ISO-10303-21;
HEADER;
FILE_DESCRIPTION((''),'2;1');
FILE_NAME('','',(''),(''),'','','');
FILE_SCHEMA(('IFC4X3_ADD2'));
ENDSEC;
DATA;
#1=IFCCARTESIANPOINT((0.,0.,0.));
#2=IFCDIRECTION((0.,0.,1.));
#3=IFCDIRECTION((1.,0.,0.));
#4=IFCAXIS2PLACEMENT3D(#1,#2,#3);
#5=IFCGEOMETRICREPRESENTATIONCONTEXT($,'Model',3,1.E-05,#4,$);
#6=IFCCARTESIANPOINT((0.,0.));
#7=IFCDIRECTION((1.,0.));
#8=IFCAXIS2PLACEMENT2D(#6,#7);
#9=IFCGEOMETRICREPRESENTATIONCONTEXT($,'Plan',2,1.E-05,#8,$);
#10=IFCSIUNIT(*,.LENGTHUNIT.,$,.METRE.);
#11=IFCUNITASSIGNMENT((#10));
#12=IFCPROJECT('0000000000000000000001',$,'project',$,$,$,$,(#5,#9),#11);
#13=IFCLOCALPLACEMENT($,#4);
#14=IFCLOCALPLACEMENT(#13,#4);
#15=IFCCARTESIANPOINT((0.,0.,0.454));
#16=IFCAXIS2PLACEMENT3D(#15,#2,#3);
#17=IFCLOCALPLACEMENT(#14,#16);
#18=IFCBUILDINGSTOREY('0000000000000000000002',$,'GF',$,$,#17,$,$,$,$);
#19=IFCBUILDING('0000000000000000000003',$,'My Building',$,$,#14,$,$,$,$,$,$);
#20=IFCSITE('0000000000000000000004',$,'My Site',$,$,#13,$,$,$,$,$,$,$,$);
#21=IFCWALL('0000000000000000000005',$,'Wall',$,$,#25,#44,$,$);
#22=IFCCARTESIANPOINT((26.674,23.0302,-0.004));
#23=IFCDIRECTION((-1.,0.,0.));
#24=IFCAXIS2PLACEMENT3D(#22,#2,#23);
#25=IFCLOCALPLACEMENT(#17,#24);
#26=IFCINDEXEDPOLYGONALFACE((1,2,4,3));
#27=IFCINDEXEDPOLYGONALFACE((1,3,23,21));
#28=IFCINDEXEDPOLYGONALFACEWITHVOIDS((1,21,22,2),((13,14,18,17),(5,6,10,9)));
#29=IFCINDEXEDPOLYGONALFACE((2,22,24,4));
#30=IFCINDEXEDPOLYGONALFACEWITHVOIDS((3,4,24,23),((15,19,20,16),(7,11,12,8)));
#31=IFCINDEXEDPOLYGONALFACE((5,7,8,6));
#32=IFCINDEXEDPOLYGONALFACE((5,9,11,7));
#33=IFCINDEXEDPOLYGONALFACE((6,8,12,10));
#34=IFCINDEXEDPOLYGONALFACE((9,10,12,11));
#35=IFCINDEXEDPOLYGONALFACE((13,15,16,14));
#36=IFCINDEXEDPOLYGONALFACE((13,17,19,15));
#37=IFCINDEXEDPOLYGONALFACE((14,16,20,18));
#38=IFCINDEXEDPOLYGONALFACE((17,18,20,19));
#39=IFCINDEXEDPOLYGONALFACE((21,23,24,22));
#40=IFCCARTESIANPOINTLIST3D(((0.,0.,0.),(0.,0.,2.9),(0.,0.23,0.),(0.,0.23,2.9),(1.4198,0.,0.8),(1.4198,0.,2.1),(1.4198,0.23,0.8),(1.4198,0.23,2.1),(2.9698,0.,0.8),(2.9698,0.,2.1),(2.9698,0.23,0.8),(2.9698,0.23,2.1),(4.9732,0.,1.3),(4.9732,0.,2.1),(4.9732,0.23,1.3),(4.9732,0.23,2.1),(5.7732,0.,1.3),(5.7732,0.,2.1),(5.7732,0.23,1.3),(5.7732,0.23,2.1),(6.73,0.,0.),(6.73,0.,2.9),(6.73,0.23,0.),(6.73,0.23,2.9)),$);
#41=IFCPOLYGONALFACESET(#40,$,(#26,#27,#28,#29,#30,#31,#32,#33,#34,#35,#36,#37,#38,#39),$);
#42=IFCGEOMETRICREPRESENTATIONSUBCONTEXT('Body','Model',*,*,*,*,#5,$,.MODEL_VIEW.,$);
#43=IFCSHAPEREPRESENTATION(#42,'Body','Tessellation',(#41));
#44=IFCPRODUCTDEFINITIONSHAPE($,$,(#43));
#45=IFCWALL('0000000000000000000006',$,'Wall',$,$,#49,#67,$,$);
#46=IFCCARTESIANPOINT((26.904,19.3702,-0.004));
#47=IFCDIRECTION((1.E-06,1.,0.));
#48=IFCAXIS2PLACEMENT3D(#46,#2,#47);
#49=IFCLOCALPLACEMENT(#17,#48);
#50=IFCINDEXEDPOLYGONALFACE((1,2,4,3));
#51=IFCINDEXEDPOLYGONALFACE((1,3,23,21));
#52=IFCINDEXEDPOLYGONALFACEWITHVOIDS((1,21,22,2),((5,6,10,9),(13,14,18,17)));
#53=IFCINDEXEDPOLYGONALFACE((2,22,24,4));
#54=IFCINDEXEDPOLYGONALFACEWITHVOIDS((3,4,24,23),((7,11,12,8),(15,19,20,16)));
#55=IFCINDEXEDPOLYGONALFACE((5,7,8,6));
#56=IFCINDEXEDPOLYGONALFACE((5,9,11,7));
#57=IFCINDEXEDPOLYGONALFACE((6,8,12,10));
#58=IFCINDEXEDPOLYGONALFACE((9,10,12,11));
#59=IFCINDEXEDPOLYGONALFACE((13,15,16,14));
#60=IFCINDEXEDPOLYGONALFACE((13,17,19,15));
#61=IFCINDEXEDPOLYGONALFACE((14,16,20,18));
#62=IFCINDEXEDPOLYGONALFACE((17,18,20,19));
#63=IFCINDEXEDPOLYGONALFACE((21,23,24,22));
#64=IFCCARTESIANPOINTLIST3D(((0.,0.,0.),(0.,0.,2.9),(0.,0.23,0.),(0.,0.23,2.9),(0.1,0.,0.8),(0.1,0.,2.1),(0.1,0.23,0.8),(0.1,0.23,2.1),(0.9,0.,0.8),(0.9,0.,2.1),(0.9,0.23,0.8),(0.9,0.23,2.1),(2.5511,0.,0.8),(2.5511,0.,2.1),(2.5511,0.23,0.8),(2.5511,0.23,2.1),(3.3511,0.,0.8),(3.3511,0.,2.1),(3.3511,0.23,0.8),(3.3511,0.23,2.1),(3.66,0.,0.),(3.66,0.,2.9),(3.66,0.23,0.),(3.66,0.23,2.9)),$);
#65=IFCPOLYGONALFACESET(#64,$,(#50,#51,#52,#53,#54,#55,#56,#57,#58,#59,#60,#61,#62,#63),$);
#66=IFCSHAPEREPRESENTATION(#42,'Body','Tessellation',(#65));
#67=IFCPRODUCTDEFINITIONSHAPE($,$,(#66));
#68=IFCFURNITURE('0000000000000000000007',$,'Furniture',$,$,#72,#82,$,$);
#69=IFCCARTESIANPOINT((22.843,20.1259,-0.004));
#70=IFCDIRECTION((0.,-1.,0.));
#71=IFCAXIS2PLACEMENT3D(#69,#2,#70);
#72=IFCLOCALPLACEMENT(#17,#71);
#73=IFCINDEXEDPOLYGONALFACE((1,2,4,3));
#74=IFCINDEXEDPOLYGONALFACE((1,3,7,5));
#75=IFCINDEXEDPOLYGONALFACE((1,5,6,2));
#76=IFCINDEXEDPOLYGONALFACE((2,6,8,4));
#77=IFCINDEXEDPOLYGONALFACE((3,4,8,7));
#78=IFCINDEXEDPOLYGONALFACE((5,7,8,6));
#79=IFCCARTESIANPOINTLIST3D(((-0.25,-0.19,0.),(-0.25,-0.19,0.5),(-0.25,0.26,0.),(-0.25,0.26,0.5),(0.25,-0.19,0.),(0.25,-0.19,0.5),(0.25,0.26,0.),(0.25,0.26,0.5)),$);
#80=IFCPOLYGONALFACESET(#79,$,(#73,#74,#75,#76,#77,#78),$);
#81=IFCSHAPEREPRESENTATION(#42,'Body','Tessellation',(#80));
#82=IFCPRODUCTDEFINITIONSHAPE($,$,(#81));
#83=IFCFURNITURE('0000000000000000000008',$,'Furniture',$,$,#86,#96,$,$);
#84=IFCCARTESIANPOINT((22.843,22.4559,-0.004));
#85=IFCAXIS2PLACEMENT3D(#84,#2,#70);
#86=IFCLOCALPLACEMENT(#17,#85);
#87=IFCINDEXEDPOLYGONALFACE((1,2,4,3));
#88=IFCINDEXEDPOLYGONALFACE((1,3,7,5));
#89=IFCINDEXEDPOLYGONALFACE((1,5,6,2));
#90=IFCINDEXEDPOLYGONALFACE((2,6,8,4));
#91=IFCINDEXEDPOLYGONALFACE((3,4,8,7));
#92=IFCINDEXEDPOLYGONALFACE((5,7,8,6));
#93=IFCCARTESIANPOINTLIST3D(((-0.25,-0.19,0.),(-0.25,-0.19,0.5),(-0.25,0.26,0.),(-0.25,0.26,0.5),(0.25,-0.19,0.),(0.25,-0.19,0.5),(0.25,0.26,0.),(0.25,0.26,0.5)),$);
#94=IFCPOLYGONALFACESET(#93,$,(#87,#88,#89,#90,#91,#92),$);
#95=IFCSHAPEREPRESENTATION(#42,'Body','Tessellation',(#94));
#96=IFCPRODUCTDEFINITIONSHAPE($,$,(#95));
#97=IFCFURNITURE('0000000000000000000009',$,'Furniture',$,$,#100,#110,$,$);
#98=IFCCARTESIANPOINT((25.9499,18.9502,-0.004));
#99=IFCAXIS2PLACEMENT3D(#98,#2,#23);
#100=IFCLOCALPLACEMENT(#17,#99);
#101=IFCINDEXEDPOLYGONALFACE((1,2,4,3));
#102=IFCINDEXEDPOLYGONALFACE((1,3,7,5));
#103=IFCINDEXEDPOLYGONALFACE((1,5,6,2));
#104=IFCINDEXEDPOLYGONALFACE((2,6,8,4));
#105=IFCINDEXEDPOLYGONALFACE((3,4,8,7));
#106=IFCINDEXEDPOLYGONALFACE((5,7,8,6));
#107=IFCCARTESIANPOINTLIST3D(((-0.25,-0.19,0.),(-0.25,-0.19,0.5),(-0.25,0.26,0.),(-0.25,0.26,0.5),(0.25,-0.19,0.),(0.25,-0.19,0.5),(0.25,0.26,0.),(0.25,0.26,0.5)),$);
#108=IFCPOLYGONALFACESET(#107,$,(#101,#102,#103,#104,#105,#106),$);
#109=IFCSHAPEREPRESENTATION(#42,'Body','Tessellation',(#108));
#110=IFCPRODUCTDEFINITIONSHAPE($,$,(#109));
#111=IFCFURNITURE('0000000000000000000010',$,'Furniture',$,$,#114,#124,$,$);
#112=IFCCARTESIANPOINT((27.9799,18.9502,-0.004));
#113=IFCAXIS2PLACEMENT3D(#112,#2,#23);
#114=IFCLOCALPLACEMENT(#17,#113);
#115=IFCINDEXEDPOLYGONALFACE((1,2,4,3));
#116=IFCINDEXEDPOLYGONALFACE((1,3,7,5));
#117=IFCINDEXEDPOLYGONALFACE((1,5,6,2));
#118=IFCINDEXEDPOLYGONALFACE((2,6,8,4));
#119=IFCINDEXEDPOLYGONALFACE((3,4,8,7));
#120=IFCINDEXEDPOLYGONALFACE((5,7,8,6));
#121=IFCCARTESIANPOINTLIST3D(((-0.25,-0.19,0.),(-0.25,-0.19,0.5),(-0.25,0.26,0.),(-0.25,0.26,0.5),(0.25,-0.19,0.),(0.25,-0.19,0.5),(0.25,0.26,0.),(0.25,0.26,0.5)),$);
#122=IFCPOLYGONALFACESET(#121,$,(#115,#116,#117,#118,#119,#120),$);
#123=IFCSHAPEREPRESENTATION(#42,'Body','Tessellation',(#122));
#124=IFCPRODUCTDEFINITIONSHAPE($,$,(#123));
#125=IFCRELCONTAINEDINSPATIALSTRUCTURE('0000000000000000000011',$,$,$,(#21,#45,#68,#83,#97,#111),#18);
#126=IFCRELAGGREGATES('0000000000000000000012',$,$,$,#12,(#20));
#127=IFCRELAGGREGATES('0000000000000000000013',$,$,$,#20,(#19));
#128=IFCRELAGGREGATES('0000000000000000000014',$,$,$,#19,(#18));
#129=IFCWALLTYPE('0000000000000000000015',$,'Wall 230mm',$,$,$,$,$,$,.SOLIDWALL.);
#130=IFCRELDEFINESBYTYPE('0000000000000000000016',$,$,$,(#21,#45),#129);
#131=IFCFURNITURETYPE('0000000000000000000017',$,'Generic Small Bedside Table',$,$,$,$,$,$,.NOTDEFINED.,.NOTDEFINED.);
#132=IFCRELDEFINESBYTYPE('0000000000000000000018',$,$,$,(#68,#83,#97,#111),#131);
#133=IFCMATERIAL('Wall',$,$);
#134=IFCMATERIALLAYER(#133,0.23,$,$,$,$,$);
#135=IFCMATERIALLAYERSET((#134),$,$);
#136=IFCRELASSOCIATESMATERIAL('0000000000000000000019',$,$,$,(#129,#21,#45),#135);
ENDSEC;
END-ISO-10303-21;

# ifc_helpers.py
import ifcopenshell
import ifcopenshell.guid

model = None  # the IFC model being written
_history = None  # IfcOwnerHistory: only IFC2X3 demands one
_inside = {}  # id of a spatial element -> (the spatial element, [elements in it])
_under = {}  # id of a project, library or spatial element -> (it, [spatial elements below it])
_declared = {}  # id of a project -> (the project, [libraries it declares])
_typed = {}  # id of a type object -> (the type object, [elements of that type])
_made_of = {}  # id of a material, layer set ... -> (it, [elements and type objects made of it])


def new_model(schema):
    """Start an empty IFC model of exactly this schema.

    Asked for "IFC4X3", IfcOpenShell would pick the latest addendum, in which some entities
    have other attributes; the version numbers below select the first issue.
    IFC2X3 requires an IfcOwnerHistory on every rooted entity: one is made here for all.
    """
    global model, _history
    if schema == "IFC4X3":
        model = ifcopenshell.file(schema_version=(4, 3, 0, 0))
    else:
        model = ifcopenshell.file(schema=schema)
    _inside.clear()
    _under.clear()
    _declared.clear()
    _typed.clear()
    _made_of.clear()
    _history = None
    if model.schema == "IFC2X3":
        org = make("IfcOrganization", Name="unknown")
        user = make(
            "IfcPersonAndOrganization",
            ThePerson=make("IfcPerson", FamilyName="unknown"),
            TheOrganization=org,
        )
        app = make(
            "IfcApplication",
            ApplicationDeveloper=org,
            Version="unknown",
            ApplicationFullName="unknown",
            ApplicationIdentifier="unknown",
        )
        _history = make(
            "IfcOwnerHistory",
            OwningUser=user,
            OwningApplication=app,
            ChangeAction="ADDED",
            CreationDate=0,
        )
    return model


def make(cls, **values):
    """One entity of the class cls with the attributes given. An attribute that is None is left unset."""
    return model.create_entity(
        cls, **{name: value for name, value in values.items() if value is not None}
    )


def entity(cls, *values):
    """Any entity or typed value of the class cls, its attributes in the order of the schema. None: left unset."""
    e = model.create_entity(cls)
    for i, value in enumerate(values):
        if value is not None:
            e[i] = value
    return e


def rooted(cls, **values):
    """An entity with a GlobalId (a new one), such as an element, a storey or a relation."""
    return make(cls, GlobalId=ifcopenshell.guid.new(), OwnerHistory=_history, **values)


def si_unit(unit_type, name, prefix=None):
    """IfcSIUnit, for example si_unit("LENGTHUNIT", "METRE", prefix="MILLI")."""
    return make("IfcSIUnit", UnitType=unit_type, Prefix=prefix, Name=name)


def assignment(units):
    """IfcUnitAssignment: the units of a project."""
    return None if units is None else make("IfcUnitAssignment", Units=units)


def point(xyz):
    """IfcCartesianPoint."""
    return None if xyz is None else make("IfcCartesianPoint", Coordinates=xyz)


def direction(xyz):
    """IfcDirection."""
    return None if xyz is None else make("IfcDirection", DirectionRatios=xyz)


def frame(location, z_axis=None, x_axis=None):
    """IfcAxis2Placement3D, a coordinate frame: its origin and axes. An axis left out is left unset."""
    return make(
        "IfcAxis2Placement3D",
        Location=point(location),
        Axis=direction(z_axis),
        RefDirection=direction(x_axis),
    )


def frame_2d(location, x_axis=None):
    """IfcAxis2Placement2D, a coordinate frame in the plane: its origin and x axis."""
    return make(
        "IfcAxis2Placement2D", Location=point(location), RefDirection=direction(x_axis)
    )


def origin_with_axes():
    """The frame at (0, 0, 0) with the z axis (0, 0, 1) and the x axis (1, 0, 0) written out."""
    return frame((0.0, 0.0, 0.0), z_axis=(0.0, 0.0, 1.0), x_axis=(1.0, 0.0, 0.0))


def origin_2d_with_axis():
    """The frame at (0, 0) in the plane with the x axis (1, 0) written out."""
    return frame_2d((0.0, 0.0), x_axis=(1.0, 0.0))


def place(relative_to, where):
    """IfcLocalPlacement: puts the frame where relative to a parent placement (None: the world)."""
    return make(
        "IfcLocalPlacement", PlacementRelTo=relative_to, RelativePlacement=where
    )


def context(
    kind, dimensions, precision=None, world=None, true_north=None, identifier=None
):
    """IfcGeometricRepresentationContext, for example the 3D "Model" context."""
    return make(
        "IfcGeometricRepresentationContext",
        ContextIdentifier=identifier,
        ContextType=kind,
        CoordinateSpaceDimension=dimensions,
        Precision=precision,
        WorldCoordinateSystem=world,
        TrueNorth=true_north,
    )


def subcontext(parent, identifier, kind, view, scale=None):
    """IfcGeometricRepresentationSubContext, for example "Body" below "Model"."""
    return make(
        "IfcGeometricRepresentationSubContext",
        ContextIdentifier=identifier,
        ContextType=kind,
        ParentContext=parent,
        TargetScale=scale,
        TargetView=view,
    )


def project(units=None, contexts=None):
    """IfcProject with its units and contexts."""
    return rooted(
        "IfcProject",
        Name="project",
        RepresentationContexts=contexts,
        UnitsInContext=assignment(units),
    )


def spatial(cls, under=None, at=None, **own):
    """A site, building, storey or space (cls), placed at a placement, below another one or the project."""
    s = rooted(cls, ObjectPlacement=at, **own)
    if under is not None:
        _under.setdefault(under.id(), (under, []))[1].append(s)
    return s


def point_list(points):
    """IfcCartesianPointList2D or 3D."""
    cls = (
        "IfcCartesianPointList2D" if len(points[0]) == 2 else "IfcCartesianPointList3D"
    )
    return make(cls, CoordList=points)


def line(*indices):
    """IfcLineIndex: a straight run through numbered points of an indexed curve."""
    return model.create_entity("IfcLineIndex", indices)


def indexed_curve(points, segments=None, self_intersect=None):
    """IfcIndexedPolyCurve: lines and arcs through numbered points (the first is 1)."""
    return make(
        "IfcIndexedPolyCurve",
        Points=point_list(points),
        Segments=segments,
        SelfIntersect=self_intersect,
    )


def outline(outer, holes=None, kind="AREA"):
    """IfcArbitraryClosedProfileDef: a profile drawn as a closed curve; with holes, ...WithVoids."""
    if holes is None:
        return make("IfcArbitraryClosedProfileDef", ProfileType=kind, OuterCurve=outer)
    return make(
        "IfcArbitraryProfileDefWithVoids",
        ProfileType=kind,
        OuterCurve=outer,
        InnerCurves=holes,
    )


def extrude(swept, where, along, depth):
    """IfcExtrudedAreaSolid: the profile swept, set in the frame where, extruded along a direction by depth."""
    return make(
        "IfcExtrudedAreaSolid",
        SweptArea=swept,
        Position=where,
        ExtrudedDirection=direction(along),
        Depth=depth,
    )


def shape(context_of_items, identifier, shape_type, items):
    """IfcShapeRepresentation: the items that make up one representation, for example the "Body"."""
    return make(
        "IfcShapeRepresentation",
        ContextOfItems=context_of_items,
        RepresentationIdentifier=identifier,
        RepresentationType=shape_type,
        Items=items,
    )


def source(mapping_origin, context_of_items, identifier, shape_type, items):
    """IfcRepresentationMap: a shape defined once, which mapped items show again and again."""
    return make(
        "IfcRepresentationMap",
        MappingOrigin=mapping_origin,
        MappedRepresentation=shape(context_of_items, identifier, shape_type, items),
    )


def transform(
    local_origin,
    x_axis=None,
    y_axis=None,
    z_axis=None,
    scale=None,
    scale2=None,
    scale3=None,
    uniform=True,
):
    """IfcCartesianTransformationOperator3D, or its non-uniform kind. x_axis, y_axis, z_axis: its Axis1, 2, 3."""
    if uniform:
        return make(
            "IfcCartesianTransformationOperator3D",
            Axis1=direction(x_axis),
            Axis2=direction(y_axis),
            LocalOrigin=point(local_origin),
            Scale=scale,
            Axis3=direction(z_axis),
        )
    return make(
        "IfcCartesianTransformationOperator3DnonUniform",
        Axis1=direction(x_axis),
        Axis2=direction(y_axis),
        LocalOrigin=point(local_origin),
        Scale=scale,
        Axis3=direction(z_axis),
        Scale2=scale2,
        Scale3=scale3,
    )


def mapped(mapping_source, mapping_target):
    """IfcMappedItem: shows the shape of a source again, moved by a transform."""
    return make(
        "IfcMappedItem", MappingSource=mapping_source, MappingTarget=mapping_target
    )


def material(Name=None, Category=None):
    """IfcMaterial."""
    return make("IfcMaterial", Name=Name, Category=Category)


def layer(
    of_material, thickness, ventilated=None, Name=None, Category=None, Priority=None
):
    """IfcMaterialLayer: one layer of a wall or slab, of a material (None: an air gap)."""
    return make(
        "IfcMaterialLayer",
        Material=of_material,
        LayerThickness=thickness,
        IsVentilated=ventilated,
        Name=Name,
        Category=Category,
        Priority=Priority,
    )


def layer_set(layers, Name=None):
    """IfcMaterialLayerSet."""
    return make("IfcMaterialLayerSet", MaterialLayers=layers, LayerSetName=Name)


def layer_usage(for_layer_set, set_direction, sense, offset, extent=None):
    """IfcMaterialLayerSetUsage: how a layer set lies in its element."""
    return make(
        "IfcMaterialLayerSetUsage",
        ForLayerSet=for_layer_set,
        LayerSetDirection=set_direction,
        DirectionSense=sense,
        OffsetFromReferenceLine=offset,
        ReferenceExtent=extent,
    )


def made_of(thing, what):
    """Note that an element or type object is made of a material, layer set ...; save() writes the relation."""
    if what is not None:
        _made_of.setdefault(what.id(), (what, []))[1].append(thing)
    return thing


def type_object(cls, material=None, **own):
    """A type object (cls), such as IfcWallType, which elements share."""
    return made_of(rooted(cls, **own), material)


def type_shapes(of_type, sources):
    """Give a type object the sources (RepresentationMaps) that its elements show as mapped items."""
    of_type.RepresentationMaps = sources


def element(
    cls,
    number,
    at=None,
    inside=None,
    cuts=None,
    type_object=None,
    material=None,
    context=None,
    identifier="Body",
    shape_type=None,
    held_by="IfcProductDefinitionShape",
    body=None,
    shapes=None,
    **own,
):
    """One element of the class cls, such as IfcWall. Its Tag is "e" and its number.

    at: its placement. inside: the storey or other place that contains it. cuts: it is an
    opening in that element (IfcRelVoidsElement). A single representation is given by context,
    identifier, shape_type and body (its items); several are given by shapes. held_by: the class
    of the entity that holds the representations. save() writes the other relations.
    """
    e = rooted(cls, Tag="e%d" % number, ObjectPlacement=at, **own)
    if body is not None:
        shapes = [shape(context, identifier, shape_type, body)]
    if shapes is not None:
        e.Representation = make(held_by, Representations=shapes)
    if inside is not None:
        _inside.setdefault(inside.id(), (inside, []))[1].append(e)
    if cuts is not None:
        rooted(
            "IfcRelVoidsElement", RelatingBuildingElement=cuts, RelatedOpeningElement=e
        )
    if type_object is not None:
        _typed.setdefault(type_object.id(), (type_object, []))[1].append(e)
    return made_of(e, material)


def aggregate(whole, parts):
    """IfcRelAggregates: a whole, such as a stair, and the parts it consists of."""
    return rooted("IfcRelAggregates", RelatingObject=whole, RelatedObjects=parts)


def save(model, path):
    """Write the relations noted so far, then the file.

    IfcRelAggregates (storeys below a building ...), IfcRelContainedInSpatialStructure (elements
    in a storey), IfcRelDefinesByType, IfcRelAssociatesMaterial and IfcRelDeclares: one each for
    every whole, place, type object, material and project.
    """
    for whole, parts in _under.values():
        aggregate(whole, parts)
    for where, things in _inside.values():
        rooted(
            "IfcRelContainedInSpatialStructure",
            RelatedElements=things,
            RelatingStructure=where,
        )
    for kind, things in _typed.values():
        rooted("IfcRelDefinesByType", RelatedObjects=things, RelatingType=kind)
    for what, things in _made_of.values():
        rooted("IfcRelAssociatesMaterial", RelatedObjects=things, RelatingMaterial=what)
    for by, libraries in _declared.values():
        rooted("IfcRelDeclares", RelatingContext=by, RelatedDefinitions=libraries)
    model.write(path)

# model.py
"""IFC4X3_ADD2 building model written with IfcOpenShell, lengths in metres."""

from ifc_helpers import new_model, entity, si_unit, frame, origin_with_axes, origin_2d_with_axis, place, context, subcontext, project, spatial, line, indexed_curve, outline, extrude, shape, source, transform, mapped, material, layer, layer_set, layer_usage, type_object, type_shapes, element, save


model = new_model("IFC4X3_ADD2")

# Units and contexts
model_context = context("Model", 3, precision=1e-05, world=origin_with_axes())
plan_context = context("Plan", 2, precision=1e-05, world=origin_2d_with_axis())
body_context_1 = subcontext(model_context, "Body", "Model", "MODEL_VIEW")
body_context_2 = subcontext(plan_context, "Body", "Plan", "PLAN_VIEW")
ifc_project = project(units=[si_unit("LENGTHUNIT", "METRE")], contexts=[model_context, plan_context])

# Site, building, storey
site_placement = place(None, origin_with_axes())
site = spatial("IfcSite", under=ifc_project, at=site_placement, Name="My Site")
building_placement = place(site_placement, origin_with_axes())
building = spatial("IfcBuilding", under=site, at=building_placement, Name="My Building")
storey_placement = place(building_placement, frame((0.0, 0.0, 0.454), z_axis=(0.0, 0.0, 1.0), x_axis=(1.0, 0.0, 0.0)))
storey = spatial("IfcBuildingStorey", under=building, at=storey_placement, Name="GF")

# Shared definitions
ifc_material_1 = material(Name="Wall")

# Walls, openings
ifc_layer_1 = layer(ifc_material_1, 0.23)
ifc_layer_set_1 = layer_set([ifc_layer_1])
ifc_layer_usage_1 = layer_usage(ifc_layer_set_1, "AXIS2", "POSITIVE", 0.0)
wall_type_1 = type_object("IfcWallType", Name="Wall 230mm", PredefinedType="SOLIDWALL", material=ifc_layer_set_1)
wall_1_placement = place(storey_placement, frame((26.674, 23.0302, -0.004), z_axis=(0.0, 0.0, 1.0), x_axis=(-1.0, 0.0, 0.0)))
wall_1 = element("IfcWall", 1, at=wall_1_placement, inside=storey, type_object=wall_type_1, material=ifc_layer_usage_1, Name="Wall", context=body_context_1, shape_type="SweptSolid", body=[
    extrude(outline(indexed_curve([(0.0, 0.0), (0.0, 0.23), (6.73, 0.23), (6.73, 0.0), (0.0, 0.0)], self_intersect=False)), origin_with_axes(), (0.0, 0.0, 1.0), 2.9),
])
shared_shape_1 = source(origin_with_axes(), body_context_1, "Body", "SweptSolid", [
    extrude(outline(indexed_curve([(0.0, 0.0), (0.8, 0.0), (0.8, 0.8), (0.0, 0.8)], segments=[line(1, 2, 3, 4, 1)])), frame((-0.4, -0.6, 0.0), z_axis=(0.0, -1.0, 0.0), x_axis=(1.0, 0.0, 0.0)), (0.0, 0.0, -1.0), 1.2),
])
opening_1_placement = place(wall_1_placement, frame((5.3732, 0.16, 1.3), z_axis=(0.0, 0.0, 1.0), x_axis=(1.0, 0.0, 0.0)))
element("IfcOpeningElement", 2, at=opening_1_placement, cuts=wall_1, PredefinedType="OPENING", context=body_context_1, shape_type="MappedRepresentation", body=[
    mapped(shared_shape_1, transform((0.0, 0.0, 0.0), x_axis=(1.0, 0.0, 0.0), y_axis=(0.0, 1.0, 0.0), z_axis=(0.0, 0.0, 1.0), scale=1.0)),
])
shared_shape_2 = source(origin_with_axes(), body_context_1, "Body", "SweptSolid", [
    extrude(outline(indexed_curve([(0.0, 0.0), (1.55, 0.0), (1.55, 1.3), (0.0, 1.3)], segments=[line(1, 2, 3, 4, 1)])), frame((-0.775, -0.6, 0.0), z_axis=(0.0, -1.0, 0.0), x_axis=(1.0, 0.0, 0.0)), (0.0, 0.0, -1.0), 1.2),
])
opening_2_placement = place(wall_1_placement, frame((2.1948, 0.16, 0.8), z_axis=(0.0, 0.0, 1.0), x_axis=(1.0, 0.0, 0.0)))
element("IfcOpeningElement", 3, at=opening_2_placement, cuts=wall_1, PredefinedType="OPENING", context=body_context_1, shape_type="MappedRepresentation", body=[
    mapped(shared_shape_2, transform((0.0, 0.0, 0.0), x_axis=(1.0, 0.0, 0.0), y_axis=(0.0, 1.0, 0.0), z_axis=(0.0, 0.0, 1.0), scale=1.0)),
])
ifc_layer_usage_2 = layer_usage(ifc_layer_set_1, "AXIS2", "POSITIVE", 0.0)
wall_2_placement = place(storey_placement, frame((26.904, 19.3702, -0.004), z_axis=(0.0, 0.0, 1.0), x_axis=(0.000001, 1.0, 0.0)))
wall_2 = element("IfcWall", 4, at=wall_2_placement, inside=storey, type_object=wall_type_1, material=ifc_layer_usage_2, Name="Wall", context=body_context_1, shape_type="SweptSolid", body=[
    extrude(outline(indexed_curve([(0.0, 0.0), (0.0, 0.23), (3.66, 0.23), (3.66, 0.0), (0.0, 0.0)], self_intersect=False)), origin_with_axes(), (0.0, 0.0, 1.0), 2.9),
])
shared_shape_3 = source(origin_with_axes(), body_context_1, "Body", "SweptSolid", [
    extrude(outline(indexed_curve([(0.0, 0.0), (0.8, 0.0), (0.8, 1.3), (0.0, 1.3)], segments=[line(1, 2, 3, 4, 1)])), frame((-0.4, -0.6, 0.0), z_axis=(0.0, -1.0, 0.0), x_axis=(1.0, 0.0, 0.0)), (0.0, 0.0, -1.0), 1.2),
])
opening_3_placement = place(wall_2_placement, frame((0.5, 0.16, 0.8), z_axis=(0.0, 0.0, 1.0), x_axis=(1.0, 0.0, 0.0)))
element("IfcOpeningElement", 5, at=opening_3_placement, cuts=wall_2, PredefinedType="OPENING", context=body_context_1, shape_type="MappedRepresentation", body=[
    mapped(shared_shape_3, transform((0.0, 0.0, 0.0), x_axis=(1.0, 0.0, 0.0), y_axis=(0.0, 1.0, 0.0), z_axis=(0.0, 0.0, 1.0), scale=1.0)),
])
opening_4_placement = place(wall_2_placement, frame((2.9511, 0.16, 0.8), z_axis=(0.0, 0.0, 1.0), x_axis=(1.0, 0.0, 0.0)))
element("IfcOpeningElement", 6, at=opening_4_placement, cuts=wall_2, PredefinedType="OPENING", context=body_context_1, shape_type="MappedRepresentation", body=[
    mapped(shared_shape_3, transform((0.0, 0.0, 0.0), x_axis=(1.0, 0.0, 0.0), y_axis=(0.0, 1.0, 0.0), z_axis=(0.0, 0.0, 1.0), scale=1.0)),
])

# Furniture
furniture_type_1 = type_object("IfcFurnitureType", Name="Generic Small Bedside Table", AssemblyPlace="NOTDEFINED", PredefinedType="NOTDEFINED")
shared_shape_4 = source(origin_with_axes(), body_context_1, "Body", "SweptSolid", [
    extrude(outline(indexed_curve([(0.5, 0.45), (0.5, 0.0), (0.0, 0.0), (0.0, 0.45)], segments=[line(4, 1), line(1, 2), line(2, 3), line(3, 4)], self_intersect=False)), frame((-0.25, -0.19, 0.0), z_axis=(0.0, 0.0, 1.0), x_axis=(1.0, 0.0, 0.0)), (0.0, 0.0, 1.0), 0.5),
])
shared_shape_5 = source(origin_with_axes(), body_context_2, "Body", "Annotation2D", [
    entity("IfcGeometricCurveSet", [entity("IfcIndexedPolyCurve", entity("IfcCartesianPointList2D", [[-0.25, -0.19], [0.25, -0.19], [0.25, 0.26], [-0.25, 0.26]]), [entity("IfcLineIndex", [1, 2]), entity("IfcLineIndex", [2, 3]), entity("IfcLineIndex", [3, 4]), entity("IfcLineIndex", [4, 1])])]),
])
type_shapes(furniture_type_1, [shared_shape_4, shared_shape_5])
for number, where, z_axis, x_axis, name in (
    (7, (22.843, 20.1259, -0.004), (0.0, 0.0, 1.0), (0.0, -1.0, 0.0), "Furniture"),
    (8, (22.843, 22.4559, -0.004), (0.0, 0.0, 1.0), (0.0, -1.0, 0.0), "Furniture"),
    (9, (25.9499, 18.9502, -0.004), (0.0, 0.0, 1.0), (-1.0, 0.0, 0.0), "Furniture"),
    (10, (27.9799, 18.9502, -0.004), (0.0, 0.0, 1.0), (-1.0, 0.0, 0.0), "Furniture"),
):
    element("IfcFurniture", number, at=place(storey_placement, frame(where, z_axis=z_axis, x_axis=x_axis)), inside=storey, type_object=furniture_type_1, Name=name, shapes=[
        shape(body_context_1, "Body", "MappedRepresentation", [mapped(shared_shape_4, transform((0.0, 0.0, 0.0), x_axis=(1.0, 0.0, 0.0), y_axis=(0.0, 1.0, 0.0), z_axis=(0.0, 0.0, 1.0), scale=1.0))]),
        shape(body_context_2, "Body", "MappedRepresentation", [mapped(shared_shape_5, transform((0.0, 0.0, 0.0), x_axis=(1.0, 0.0, 0.0), y_axis=(0.0, 1.0, 0.0), z_axis=(0.0, 0.0, 1.0), scale=1.0))]),
    ])

save(model, "model.ifc")
